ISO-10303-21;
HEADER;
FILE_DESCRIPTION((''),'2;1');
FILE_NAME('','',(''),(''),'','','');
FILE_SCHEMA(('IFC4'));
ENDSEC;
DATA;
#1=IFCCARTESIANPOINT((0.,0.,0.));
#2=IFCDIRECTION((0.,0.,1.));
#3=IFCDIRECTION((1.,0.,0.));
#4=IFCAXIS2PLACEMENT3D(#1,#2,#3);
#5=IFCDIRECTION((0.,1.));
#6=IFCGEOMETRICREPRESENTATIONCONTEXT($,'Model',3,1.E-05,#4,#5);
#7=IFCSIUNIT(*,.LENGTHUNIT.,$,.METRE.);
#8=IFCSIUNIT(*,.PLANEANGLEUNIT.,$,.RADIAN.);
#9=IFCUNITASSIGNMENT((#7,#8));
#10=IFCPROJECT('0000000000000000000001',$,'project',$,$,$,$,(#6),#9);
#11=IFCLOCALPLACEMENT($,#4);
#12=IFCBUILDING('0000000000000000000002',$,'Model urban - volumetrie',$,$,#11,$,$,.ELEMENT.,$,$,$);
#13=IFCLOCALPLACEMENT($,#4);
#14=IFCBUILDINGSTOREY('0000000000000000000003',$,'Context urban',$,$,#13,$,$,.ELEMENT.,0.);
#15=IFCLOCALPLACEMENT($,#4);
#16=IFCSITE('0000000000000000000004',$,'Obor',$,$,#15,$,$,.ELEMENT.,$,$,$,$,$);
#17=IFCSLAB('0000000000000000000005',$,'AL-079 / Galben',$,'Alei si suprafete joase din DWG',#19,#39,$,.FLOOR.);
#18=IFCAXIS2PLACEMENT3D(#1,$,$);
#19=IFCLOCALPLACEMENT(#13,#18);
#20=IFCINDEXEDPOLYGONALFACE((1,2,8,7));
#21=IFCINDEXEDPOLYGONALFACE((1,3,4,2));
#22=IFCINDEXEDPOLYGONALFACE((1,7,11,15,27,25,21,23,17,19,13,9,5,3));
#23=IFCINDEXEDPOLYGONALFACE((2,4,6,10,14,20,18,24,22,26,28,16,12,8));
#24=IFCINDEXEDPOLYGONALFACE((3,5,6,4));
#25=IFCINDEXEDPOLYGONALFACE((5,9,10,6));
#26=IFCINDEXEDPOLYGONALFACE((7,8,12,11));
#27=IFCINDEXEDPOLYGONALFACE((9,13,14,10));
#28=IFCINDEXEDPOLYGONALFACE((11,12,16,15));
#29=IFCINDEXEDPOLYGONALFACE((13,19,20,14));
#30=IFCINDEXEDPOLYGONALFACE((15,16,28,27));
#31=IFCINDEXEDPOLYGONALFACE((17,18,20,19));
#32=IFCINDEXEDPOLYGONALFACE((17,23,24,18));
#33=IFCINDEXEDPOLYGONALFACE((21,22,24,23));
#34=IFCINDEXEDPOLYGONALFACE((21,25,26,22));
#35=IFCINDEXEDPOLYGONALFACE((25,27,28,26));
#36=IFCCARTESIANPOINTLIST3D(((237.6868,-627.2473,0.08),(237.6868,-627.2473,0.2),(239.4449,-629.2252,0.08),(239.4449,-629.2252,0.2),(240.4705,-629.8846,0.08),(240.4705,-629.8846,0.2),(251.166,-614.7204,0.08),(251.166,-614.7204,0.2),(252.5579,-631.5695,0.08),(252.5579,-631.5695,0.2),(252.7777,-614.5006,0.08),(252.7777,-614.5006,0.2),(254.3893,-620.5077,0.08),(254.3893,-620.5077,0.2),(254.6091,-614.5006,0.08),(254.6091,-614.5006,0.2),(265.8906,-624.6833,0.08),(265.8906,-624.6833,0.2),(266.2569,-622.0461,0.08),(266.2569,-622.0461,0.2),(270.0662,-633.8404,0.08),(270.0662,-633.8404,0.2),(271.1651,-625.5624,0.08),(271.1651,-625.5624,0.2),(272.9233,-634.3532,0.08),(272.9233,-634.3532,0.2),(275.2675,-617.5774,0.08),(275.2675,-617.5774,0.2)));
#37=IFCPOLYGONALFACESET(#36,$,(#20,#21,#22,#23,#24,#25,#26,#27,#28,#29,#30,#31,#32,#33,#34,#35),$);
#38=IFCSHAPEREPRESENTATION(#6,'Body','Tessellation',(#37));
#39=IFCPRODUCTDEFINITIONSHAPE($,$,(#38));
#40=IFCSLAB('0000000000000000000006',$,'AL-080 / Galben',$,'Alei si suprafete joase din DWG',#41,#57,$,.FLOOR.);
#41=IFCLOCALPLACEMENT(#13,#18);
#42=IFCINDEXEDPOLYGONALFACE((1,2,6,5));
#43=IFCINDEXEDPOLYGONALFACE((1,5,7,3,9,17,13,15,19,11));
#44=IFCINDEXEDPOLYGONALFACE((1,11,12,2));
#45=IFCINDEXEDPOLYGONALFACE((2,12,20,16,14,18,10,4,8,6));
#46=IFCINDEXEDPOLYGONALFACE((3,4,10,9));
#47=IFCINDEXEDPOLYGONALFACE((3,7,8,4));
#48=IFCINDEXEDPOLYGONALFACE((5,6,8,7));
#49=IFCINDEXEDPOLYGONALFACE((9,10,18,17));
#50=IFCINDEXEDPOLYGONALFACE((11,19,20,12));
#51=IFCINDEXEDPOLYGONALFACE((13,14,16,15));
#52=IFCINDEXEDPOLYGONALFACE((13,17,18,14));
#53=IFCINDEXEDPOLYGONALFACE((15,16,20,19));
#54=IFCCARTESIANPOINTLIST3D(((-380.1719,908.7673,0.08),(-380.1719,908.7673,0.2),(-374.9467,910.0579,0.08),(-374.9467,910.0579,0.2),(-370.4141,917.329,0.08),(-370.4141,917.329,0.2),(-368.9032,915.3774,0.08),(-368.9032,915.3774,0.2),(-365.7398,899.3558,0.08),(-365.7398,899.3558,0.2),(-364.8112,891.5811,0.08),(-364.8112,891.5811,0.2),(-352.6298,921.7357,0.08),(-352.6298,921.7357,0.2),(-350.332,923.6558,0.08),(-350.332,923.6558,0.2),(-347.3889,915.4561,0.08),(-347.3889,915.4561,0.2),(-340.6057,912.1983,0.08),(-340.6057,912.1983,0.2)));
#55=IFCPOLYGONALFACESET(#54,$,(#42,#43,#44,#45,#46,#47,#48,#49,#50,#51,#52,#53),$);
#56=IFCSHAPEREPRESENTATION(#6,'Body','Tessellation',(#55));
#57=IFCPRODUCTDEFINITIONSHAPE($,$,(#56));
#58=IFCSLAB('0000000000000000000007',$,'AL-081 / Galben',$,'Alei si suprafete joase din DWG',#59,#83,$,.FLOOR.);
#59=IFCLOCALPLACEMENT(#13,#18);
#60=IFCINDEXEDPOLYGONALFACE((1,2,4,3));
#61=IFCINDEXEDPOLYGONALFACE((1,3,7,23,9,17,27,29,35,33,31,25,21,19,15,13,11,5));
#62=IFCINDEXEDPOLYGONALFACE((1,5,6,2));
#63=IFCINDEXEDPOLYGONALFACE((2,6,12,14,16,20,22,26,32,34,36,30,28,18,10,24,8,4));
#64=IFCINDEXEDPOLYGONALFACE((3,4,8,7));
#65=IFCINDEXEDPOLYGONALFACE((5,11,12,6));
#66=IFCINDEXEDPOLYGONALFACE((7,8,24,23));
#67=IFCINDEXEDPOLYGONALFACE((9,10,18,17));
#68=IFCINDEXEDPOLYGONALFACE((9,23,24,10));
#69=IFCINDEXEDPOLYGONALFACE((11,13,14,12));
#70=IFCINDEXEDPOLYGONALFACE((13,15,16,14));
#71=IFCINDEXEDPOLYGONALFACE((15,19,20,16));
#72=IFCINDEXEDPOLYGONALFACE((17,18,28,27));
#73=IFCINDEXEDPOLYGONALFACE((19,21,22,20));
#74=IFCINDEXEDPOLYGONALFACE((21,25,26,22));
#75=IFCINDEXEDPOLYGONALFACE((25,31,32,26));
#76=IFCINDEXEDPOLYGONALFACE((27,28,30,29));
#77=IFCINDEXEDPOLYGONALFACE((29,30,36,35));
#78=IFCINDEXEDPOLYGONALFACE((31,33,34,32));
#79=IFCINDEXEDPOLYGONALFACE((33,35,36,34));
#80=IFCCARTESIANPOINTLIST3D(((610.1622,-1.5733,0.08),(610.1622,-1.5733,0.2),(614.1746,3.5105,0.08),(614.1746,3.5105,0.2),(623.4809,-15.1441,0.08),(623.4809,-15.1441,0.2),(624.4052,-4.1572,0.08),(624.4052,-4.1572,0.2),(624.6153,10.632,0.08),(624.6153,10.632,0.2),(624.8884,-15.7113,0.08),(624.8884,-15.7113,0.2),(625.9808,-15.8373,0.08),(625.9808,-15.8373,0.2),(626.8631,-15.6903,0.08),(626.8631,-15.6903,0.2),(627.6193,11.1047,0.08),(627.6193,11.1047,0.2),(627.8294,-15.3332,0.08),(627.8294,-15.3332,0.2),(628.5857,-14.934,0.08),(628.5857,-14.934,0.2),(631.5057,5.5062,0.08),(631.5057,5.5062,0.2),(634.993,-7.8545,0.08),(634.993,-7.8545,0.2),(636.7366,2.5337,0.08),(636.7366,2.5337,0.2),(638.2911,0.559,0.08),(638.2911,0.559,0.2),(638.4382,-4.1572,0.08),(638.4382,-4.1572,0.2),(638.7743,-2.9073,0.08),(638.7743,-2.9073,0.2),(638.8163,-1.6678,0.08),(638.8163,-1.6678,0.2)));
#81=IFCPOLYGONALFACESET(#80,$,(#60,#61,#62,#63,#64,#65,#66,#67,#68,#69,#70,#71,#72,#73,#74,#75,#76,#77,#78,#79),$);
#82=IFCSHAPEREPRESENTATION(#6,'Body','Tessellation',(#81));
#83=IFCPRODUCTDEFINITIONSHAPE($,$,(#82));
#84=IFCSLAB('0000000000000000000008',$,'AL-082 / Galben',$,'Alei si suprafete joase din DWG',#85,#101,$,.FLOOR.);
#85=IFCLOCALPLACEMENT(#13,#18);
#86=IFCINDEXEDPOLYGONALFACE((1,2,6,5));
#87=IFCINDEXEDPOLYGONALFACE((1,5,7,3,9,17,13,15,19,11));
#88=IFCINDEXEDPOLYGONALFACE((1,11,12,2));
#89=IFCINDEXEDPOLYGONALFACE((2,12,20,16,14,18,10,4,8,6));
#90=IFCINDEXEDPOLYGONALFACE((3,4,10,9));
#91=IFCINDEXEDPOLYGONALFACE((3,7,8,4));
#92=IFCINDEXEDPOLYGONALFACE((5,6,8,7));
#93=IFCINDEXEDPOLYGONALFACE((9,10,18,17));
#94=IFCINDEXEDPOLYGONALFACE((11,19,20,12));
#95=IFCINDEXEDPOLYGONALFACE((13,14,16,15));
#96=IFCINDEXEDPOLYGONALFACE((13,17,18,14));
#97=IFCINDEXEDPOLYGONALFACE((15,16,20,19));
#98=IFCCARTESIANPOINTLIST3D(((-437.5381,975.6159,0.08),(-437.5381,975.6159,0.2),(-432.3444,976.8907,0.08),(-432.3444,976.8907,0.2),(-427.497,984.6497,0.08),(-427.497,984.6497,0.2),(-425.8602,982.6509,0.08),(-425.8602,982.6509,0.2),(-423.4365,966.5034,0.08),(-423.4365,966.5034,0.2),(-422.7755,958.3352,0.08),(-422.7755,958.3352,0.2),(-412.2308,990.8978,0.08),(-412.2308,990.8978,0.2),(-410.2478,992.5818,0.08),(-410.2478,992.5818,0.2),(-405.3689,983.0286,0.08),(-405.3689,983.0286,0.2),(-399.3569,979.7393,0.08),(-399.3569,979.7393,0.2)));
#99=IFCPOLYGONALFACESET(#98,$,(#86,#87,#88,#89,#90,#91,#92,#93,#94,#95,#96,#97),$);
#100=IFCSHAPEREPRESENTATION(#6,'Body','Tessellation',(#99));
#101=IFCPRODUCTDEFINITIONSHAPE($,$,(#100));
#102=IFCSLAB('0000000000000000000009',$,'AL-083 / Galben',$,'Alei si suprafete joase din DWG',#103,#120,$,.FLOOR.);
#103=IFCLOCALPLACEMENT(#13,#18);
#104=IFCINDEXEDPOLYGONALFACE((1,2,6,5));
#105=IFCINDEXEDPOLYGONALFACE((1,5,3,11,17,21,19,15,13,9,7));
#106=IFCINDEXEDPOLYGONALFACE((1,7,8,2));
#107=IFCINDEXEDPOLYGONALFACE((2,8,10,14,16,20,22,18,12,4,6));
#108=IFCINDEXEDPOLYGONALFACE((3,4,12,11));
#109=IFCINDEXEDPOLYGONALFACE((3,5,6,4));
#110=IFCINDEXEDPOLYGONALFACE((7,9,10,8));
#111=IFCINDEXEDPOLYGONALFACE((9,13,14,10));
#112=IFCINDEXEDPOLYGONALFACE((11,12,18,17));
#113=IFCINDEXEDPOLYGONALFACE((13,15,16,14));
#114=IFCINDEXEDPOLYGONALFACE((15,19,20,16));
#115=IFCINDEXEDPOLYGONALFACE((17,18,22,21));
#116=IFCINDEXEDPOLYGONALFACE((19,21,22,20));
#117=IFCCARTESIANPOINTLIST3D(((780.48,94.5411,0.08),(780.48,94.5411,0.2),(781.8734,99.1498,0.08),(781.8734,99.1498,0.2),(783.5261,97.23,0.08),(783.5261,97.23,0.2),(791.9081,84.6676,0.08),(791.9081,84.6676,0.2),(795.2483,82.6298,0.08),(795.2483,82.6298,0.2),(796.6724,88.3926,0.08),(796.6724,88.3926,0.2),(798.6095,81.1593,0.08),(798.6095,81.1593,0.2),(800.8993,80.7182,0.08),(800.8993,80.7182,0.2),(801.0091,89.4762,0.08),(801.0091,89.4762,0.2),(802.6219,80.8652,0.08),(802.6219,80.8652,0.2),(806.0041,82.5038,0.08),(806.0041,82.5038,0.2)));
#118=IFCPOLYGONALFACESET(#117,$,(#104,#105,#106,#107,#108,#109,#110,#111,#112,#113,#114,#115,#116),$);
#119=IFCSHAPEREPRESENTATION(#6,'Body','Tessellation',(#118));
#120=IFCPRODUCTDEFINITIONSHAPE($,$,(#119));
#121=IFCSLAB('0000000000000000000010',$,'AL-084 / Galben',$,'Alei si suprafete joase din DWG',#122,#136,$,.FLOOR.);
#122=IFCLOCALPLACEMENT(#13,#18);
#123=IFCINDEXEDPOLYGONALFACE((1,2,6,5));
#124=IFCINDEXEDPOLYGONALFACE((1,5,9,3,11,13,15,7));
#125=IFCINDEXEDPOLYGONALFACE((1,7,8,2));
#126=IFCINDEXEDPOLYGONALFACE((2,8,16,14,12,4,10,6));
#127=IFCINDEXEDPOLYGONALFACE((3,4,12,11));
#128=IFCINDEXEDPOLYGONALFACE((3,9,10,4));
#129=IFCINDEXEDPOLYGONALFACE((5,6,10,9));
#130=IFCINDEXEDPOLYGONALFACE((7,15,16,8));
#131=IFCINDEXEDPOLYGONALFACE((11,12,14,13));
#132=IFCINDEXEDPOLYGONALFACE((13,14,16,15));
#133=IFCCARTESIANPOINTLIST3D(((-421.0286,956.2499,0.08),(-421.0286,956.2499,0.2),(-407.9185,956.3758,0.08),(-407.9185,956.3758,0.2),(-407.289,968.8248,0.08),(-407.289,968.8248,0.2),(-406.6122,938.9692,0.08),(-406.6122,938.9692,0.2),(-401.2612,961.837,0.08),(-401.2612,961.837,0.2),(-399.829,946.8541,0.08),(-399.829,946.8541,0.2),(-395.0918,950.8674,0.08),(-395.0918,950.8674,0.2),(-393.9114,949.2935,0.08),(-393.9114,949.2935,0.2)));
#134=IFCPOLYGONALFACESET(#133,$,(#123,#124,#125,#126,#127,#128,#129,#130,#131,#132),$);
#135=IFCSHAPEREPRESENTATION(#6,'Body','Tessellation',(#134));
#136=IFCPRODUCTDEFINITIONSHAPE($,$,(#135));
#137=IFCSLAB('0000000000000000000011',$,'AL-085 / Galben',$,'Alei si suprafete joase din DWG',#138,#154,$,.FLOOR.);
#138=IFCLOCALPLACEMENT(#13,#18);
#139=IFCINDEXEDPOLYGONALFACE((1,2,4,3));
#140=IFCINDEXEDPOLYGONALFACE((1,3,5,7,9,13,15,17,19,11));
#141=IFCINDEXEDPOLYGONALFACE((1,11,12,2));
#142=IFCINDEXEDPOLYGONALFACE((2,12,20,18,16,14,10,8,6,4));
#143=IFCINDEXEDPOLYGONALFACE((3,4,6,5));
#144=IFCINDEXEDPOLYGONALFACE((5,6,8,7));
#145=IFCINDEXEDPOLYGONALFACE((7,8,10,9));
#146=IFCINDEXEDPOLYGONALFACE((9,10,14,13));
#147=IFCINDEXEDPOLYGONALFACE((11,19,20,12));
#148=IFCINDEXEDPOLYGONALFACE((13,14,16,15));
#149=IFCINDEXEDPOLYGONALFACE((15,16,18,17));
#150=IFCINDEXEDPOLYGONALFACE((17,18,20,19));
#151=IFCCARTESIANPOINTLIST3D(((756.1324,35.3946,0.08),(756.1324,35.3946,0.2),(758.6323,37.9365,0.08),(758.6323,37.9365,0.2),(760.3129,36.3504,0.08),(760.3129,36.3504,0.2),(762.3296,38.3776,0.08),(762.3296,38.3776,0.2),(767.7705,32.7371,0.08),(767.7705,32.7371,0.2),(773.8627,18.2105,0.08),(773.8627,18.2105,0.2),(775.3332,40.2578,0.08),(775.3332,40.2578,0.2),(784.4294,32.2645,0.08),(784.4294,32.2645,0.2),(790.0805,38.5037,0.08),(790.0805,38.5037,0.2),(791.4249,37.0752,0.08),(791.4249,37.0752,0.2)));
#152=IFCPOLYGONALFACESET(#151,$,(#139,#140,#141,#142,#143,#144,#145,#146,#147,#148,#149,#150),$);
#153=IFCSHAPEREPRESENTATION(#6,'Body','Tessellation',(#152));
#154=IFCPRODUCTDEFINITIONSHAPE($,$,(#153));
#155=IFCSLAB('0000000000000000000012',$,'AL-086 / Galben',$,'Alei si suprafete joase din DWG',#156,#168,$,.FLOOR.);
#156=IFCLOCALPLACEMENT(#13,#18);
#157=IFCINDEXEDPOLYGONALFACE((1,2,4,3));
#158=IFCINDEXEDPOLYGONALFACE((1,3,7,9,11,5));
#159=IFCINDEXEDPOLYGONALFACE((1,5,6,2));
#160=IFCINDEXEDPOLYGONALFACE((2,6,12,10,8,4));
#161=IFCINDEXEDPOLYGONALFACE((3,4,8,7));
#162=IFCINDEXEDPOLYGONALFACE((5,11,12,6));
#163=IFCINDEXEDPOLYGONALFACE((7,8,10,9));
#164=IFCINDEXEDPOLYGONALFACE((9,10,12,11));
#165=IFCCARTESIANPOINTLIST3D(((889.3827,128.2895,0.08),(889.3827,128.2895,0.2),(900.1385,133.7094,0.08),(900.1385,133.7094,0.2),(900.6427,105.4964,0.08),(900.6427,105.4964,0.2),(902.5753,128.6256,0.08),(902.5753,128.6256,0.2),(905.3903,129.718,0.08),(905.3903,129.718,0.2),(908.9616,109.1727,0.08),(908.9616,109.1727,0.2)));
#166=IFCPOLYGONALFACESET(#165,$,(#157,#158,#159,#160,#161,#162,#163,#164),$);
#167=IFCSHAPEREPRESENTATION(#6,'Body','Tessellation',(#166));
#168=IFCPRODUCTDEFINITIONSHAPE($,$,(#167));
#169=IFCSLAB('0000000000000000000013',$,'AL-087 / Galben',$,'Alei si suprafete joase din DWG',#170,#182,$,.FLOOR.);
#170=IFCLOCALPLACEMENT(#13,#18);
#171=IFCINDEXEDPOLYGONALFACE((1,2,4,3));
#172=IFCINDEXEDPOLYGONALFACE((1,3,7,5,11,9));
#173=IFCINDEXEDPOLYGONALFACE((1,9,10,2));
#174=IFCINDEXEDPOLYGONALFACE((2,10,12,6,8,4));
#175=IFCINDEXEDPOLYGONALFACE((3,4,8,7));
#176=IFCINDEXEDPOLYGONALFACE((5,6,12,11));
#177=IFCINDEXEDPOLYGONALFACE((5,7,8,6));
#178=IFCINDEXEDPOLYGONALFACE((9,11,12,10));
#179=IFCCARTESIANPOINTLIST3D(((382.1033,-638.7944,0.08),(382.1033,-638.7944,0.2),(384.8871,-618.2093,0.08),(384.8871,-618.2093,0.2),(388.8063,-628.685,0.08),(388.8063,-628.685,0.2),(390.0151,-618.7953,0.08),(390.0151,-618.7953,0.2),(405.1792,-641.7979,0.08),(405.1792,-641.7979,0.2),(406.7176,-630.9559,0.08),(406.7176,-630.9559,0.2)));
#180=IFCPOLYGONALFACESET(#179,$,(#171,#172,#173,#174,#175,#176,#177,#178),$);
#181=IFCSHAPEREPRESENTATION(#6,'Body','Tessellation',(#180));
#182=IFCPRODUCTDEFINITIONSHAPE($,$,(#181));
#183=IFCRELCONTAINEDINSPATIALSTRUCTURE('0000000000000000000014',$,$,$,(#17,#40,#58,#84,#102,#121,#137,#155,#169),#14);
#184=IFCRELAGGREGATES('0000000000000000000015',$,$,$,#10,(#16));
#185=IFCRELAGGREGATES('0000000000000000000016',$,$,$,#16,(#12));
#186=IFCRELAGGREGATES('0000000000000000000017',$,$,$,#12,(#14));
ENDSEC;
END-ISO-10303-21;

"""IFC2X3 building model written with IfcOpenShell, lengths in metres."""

from ifc_helpers import new_model, si_unit, direction, frame, origin_with_axes, place, context, project, spatial, polyline, outline, extrude, element, save


model = new_model("IFC2X3")

# Units and contexts
model_context = context("Model", 3, precision=1e-05, world=origin_with_axes(), true_north=direction((0.0, 1.0)))
ifc_project = project(units=[si_unit("LENGTHUNIT", "METRE"), si_unit("PLANEANGLEUNIT", "RADIAN")], contexts=[model_context])

# Site, building, storey
site_placement = place(None, origin_with_axes())
site = spatial("IfcSite", under=ifc_project, at=site_placement, Name="Obor", CompositionType="ELEMENT")
building_placement = place(None, origin_with_axes())
building = spatial("IfcBuilding", under=site, at=building_placement, Name="Model urban - volumetrie", CompositionType="ELEMENT")
storey_placement = place(None, origin_with_axes())
storey = spatial("IfcBuildingStorey", under=building, at=storey_placement, Name="Context urban", CompositionType="ELEMENT", Elevation=0.0)

# Slabs
slab_1_placement = place(None, origin_with_axes())
element("IfcSlab", 1, at=slab_1_placement, inside=storey, Name="AL-079 / Galben", ObjectType="Alei si suprafete joase din DWG", PredefinedType="FLOOR", context=model_context, shape_type="SweptSolid", body=[
    extrude(outline(polyline([(252.7777, -614.5006), (251.166, -614.7204), (237.6868, -627.2473), (239.4449, -629.2252), (240.4705, -629.8846), (252.5579, -631.5695), (254.3893, -620.5077), (266.2569, -622.0461), (265.8906, -624.6833), (271.1651, -625.5624), (270.0662, -633.8404), (272.9233, -634.3532), (275.2675, -617.5774), (254.6091, -614.5006), (252.7777, -614.5006)])), frame((0.0, 0.0, 0.08), z_axis=(0.0, 0.0, 1.0), x_axis=(1.0, 0.0, 0.0)), (0.0, 0.0, 1.0), 0.12),
])
slab_2_placement = place(None, origin_with_axes())
element("IfcSlab", 2, at=slab_2_placement, inside=storey, Name="AL-080 / Galben", ObjectType="Alei si suprafete joase din DWG", PredefinedType="FLOOR", context=model_context, shape_type="SweptSolid", body=[
    extrude(outline(polyline([(-352.6298, 921.7357), (-347.3889, 915.4561), (-365.7398, 899.3558), (-374.9467, 910.0579), (-368.9032, 915.3774), (-370.4141, 917.329), (-380.1719, 908.7673), (-364.8112, 891.5811), (-340.6057, 912.1983), (-350.332, 923.6558), (-352.6298, 921.7357)])), frame((0.0, 0.0, 0.08), z_axis=(0.0, 0.0, 1.0), x_axis=(1.0, 0.0, 0.0)), (0.0, 0.0, 1.0), 0.12),
])
slab_3_placement = place(None, origin_with_axes())
element("IfcSlab", 3, at=slab_3_placement, inside=storey, Name="AL-081 / Galben", ObjectType="Alei si suprafete joase din DWG", PredefinedType="FLOOR", context=model_context, shape_type="SweptSolid", body=[
    extrude(outline(polyline([(636.7366, 2.5337), (627.6193, 11.1047), (624.6153, 10.632), (631.5057, 5.5062), (624.4052, -4.1572), (614.1746, 3.5105), (610.1622, -1.5733), (623.4809, -15.1441), (624.8884, -15.7113), (625.9808, -15.8373), (626.8631, -15.6903), (627.8294, -15.3332), (628.5857, -14.934), (634.993, -7.8545), (638.4382, -4.1572), (638.7743, -2.9073), (638.8163, -1.6678), (638.2911, 0.559), (636.7366, 2.5337)])), frame((0.0, 0.0, 0.08), z_axis=(0.0, 0.0, 1.0), x_axis=(1.0, 0.0, 0.0)), (0.0, 0.0, 1.0), 0.12),
])
slab_4_placement = place(None, origin_with_axes())
element("IfcSlab", 4, at=slab_4_placement, inside=storey, Name="AL-082 / Galben", ObjectType="Alei si suprafete joase din DWG", PredefinedType="FLOOR", context=model_context, shape_type="SweptSolid", body=[
    extrude(outline(polyline([(-412.2308, 990.8978), (-405.3689, 983.0286), (-423.4365, 966.5034), (-432.3444, 976.8907), (-425.8602, 982.6509), (-427.497, 984.6497), (-437.5381, 975.6159), (-422.7755, 958.3352), (-399.3569, 979.7393), (-410.2478, 992.5818), (-412.2308, 990.8978)])), frame((0.0, 0.0, 0.08), z_axis=(0.0, 0.0, 1.0), x_axis=(1.0, 0.0, 0.0)), (0.0, 0.0, 1.0), 0.12),
])
slab_5_placement = place(None, origin_with_axes())
element("IfcSlab", 5, at=slab_5_placement, inside=storey, Name="AL-083 / Galben", ObjectType="Alei si suprafete joase din DWG", PredefinedType="FLOOR", context=model_context, shape_type="SweptSolid", body=[
    extrude(outline(polyline([(795.2483, 82.6298), (798.6095, 81.1593), (800.8993, 80.7182), (802.6219, 80.8652), (806.0041, 82.5038), (801.0091, 89.4762), (796.6724, 88.3926), (781.8734, 99.1498), (783.5261, 97.23), (780.48, 94.5411), (791.9081, 84.6676), (795.2483, 82.6298)])), frame((0.0, 0.0, 0.08), z_axis=(0.0, 0.0, 1.0), x_axis=(1.0, 0.0, 0.0)), (0.0, 0.0, 1.0), 0.12),
])
slab_6_placement = place(None, origin_with_axes())
element("IfcSlab", 6, at=slab_6_placement, inside=storey, Name="AL-084 / Galben", ObjectType="Alei si suprafete joase din DWG", PredefinedType="FLOOR", context=model_context, shape_type="SweptSolid", body=[
    extrude(outline(polyline([(-395.0918, 950.8674), (-399.829, 946.8541), (-407.9185, 956.3758), (-401.2612, 961.837), (-407.289, 968.8248), (-421.0286, 956.2499), (-406.6122, 938.9692), (-393.9114, 949.2935), (-395.0918, 950.8674)])), frame((0.0, 0.0, 0.08), z_axis=(0.0, 0.0, 1.0), x_axis=(1.0, 0.0, 0.0)), (0.0, 0.0, 1.0), 0.12),
])
slab_7_placement = place(None, origin_with_axes())
element("IfcSlab", 7, at=slab_7_placement, inside=storey, Name="AL-085 / Galben", ObjectType="Alei si suprafete joase din DWG", PredefinedType="FLOOR", context=model_context, shape_type="SweptSolid", body=[
    extrude(outline(polyline([(775.3332, 40.2578), (767.7705, 32.7371), (762.3296, 38.3776), (760.3129, 36.3504), (758.6323, 37.9365), (756.1324, 35.3946), (773.8627, 18.2105), (791.4249, 37.0752), (790.0805, 38.5037), (784.4294, 32.2645), (775.3332, 40.2578)])), frame((0.0, 0.0, 0.08), z_axis=(0.0, 0.0, 1.0), x_axis=(1.0, 0.0, 0.0)), (0.0, 0.0, 1.0), 0.12),
])
slab_8_placement = place(None, origin_with_axes())
element("IfcSlab", 8, at=slab_8_placement, inside=storey, Name="AL-086 / Galben", ObjectType="Alei si suprafete joase din DWG", PredefinedType="FLOOR", context=model_context, shape_type="SweptSolid", body=[
    extrude(outline(polyline([(900.6427, 105.4964), (908.9616, 109.1727), (905.3903, 129.718), (902.5753, 128.6256), (900.1385, 133.7094), (889.3827, 128.2895), (900.6427, 105.4964)])), frame((0.0, 0.0, 0.08), z_axis=(0.0, 0.0, 1.0), x_axis=(1.0, 0.0, 0.0)), (0.0, 0.0, 1.0), 0.12),
])
slab_9_placement = place(None, origin_with_axes())
element("IfcSlab", 9, at=slab_9_placement, inside=storey, Name="AL-087 / Galben", ObjectType="Alei si suprafete joase din DWG", PredefinedType="FLOOR", context=model_context, shape_type="SweptSolid", body=[
    extrude(outline(polyline([(388.8063, -628.685), (390.0151, -618.7953), (384.8871, -618.2093), (382.1033, -638.7944), (405.1792, -641.7979), (406.7176, -630.9559), (388.8063, -628.685)])), frame((0.0, 0.0, 0.08), z_axis=(0.0, 0.0, 1.0), x_axis=(1.0, 0.0, 0.0)), (0.0, 0.0, 1.0), 0.12),
])

save(model, "model.ifc")
